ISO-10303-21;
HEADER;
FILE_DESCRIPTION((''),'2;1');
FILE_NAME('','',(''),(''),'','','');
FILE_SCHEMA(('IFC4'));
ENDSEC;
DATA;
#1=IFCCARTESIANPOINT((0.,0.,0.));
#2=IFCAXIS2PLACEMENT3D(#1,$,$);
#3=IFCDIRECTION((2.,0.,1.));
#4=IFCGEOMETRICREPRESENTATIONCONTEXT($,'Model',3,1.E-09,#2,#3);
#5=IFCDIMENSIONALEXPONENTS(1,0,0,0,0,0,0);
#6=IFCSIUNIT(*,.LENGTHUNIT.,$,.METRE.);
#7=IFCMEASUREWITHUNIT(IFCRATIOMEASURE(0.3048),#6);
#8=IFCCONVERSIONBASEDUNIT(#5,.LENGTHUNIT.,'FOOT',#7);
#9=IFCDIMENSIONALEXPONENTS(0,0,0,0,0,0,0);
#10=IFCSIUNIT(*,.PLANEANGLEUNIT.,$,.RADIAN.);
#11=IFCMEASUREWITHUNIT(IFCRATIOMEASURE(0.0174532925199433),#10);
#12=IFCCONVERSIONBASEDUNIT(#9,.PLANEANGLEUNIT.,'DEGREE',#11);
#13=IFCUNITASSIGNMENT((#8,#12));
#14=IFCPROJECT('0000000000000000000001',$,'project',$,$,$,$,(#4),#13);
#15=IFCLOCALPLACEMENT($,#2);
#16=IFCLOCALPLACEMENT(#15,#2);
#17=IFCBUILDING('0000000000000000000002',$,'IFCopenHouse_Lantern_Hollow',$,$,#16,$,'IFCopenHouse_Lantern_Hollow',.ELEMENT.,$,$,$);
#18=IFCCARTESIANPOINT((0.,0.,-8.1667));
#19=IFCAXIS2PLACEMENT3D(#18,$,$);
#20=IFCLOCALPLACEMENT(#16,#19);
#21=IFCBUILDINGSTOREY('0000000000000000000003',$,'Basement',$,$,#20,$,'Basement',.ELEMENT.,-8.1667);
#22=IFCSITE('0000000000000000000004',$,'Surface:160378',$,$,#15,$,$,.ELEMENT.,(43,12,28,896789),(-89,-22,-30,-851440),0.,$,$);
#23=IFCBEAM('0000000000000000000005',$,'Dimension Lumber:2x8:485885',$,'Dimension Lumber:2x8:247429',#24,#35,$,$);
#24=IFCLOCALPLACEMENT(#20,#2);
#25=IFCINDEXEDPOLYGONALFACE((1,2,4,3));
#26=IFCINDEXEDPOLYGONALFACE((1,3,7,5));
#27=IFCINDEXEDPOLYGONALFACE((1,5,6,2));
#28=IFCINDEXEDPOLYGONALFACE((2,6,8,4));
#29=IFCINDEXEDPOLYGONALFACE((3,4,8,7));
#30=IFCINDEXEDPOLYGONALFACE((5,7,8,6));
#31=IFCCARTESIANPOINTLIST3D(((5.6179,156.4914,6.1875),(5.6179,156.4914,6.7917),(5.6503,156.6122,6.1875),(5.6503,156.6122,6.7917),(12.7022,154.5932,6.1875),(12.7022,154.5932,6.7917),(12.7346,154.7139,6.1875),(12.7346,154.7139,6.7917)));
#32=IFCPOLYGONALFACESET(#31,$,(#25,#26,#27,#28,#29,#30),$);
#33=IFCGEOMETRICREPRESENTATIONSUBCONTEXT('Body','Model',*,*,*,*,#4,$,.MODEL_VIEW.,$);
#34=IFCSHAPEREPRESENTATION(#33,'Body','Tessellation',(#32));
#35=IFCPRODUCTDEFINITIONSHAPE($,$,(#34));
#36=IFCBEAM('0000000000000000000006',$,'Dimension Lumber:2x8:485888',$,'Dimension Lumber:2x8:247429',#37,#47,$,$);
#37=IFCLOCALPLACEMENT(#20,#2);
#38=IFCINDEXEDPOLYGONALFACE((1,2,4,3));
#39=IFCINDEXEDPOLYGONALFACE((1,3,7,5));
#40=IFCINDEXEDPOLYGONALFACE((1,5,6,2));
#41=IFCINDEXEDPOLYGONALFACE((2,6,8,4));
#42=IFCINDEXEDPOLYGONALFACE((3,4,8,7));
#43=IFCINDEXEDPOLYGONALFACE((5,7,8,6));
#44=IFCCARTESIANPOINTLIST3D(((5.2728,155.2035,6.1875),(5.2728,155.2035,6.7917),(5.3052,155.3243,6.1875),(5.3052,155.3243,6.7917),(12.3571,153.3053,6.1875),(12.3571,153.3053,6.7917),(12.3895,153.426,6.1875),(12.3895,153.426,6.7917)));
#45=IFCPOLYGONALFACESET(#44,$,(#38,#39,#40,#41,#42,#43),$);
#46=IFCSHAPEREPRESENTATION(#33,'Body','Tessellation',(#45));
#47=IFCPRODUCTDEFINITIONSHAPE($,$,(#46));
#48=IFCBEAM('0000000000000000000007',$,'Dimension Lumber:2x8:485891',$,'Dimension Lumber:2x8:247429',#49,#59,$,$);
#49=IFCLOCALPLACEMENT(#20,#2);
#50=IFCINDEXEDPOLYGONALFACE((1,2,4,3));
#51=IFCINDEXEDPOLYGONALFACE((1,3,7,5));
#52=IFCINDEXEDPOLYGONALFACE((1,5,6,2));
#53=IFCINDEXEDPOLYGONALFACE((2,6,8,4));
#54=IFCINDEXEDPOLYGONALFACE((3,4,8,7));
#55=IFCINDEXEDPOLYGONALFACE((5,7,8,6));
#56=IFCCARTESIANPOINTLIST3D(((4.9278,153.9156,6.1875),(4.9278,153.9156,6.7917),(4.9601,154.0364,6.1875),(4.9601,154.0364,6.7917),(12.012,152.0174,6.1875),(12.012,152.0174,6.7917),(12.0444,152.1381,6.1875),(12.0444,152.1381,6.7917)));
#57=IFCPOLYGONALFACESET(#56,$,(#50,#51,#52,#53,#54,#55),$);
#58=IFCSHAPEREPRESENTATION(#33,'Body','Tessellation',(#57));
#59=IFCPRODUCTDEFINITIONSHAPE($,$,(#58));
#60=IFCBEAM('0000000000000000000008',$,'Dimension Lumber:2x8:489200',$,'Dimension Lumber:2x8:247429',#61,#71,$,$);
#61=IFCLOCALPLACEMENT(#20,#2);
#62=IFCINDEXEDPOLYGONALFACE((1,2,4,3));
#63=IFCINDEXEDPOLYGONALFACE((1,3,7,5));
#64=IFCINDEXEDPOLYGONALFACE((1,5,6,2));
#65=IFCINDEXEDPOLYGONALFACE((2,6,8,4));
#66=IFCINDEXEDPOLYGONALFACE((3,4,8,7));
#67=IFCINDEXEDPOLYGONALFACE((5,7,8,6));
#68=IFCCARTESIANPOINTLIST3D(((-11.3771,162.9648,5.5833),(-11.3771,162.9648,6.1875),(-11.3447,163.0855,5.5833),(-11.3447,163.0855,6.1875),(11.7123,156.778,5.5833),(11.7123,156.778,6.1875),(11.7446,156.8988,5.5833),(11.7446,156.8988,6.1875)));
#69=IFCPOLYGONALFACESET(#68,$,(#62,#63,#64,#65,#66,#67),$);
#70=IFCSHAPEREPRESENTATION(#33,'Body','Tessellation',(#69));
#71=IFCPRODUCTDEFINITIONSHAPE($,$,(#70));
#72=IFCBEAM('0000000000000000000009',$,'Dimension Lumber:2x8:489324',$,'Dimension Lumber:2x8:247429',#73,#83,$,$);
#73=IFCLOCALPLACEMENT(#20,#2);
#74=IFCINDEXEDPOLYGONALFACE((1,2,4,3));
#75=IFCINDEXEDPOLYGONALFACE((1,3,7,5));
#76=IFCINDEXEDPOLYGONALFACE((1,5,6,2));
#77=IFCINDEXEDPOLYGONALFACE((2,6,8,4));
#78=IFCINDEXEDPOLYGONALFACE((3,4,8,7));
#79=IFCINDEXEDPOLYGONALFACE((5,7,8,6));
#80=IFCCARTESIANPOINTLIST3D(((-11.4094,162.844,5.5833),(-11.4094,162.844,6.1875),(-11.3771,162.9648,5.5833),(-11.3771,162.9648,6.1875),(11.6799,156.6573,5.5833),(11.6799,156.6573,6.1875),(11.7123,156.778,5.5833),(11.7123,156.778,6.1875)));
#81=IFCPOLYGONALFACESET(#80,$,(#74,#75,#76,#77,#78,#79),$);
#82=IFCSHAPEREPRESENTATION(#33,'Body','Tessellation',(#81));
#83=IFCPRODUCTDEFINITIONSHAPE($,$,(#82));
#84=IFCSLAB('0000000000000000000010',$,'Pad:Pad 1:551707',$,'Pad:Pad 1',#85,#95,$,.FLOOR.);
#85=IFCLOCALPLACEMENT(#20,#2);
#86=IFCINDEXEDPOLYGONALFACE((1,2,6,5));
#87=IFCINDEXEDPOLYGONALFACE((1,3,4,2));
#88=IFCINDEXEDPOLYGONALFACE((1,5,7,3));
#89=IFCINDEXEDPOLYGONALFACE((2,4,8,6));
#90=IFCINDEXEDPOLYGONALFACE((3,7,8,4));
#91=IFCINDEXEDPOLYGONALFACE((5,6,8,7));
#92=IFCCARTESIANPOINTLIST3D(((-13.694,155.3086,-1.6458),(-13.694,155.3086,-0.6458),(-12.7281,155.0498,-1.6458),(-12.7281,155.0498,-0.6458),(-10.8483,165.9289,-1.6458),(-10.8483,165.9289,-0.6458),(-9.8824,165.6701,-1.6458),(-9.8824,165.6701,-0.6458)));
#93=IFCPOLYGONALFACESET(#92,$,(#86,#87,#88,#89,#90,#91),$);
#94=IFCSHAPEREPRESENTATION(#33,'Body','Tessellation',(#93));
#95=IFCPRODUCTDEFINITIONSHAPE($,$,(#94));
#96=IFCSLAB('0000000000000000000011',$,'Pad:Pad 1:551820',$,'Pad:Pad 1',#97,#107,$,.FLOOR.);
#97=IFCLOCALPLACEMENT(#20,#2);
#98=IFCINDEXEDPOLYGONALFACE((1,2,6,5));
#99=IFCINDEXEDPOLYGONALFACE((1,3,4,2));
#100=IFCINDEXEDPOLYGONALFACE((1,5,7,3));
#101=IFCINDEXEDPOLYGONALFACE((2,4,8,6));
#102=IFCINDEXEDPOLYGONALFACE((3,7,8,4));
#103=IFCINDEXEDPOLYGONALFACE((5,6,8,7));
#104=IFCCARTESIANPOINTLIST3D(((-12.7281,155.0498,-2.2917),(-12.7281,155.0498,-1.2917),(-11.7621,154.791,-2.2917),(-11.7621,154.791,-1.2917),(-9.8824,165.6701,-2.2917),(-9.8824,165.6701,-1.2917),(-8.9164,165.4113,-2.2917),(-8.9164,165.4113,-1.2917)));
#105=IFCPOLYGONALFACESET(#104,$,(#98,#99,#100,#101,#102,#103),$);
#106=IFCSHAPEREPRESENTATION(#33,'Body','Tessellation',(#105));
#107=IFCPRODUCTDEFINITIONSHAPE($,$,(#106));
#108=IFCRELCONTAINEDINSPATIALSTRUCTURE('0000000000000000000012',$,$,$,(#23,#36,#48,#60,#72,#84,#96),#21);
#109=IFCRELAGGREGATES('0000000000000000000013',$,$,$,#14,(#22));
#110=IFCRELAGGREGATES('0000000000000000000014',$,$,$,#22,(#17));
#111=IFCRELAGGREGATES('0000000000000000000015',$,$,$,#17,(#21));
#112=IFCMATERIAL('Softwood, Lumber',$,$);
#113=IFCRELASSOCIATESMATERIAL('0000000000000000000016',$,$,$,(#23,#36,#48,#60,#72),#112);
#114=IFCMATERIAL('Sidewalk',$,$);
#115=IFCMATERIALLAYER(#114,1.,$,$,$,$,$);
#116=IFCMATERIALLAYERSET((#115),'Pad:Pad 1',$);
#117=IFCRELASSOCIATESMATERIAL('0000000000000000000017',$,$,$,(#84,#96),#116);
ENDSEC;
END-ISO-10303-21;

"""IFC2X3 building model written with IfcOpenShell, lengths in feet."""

from ifc_helpers import new_model, entity, si_unit, converted_unit, direction, frame, frame_2d, origin, place, context, subcontext, project, spatial, rectangle, extrude, material, layer, layer_set, layer_usage, element, save


model = new_model("IFC2X3")

# Units and contexts
model_context = context("Model", 3, precision=1e-09, world=origin(), true_north=direction((2.0, 0.0, 1.0)))
body_context = subcontext(model_context, "Body", "Model", "MODEL_VIEW")
ifc_project = project(units=[converted_unit("LENGTHUNIT", "FOOT", entity("IfcRatioMeasure", 0.3048), si_unit("LENGTHUNIT", "METRE"), dimensions=[1, 0, 0, 0, 0, 0, 0]), converted_unit("PLANEANGLEUNIT", "DEGREE", entity("IfcRatioMeasure", 0.0174532925199433), si_unit("PLANEANGLEUNIT", "RADIAN"), dimensions=[0, 0, 0, 0, 0, 0, 0])], contexts=[model_context])

# Site, building, storey
site_placement = place(None, origin())
site = spatial("IfcSite", under=ifc_project, at=site_placement, Name="Surface:160378", CompositionType="ELEMENT", RefLatitude=(43, 12, 28, 896789), RefLongitude=(-89, -22, -30, -851440), RefElevation=0.0)
building_placement = place(site_placement, origin())
building = spatial("IfcBuilding", under=site, at=building_placement, Name="IFCopenHouse_Lantern_Hollow", LongName="IFCopenHouse_Lantern_Hollow", CompositionType="ELEMENT")
storey_placement = place(building_placement, frame((0.0, 0.0, -8.1667)))
storey = spatial("IfcBuildingStorey", under=building, at=storey_placement, Name="Basement", LongName="Basement", CompositionType="ELEMENT", Elevation=-8.1667)

# Beams
ifc_material_1 = material(Name="Softwood, Lumber")
beam_1_placement = place(storey_placement, frame((5.6341, 156.5518, 8.1667), z_axis=(0.0, 0.0, 1.0), x_axis=(0.965926, -0.258819, 0.0)))
element("IfcBeam", 1, at=beam_1_placement, inside=storey, material=ifc_material_1, Name="Dimension Lumber:2x8:485885", ObjectType="Dimension Lumber:2x8:247429", context=body_context, shape_type="SweptSolid", body=[
    extrude(rectangle(XDim=0.6042, YDim=0.125, at=frame_2d((0.0, 0.0), x_axis=(1.0, 0.0))), frame((0.0, 0.0, -1.6771), z_axis=(1.0, 0.0, 0.0), x_axis=(0.0, 0.0, -1.0)), (0.0, 0.0, 1.0), 7.3342),
])
beam_2_placement = place(storey_placement, frame((5.289, 155.2639, 8.1667), z_axis=(0.0, 0.0, 1.0), x_axis=(0.965926, -0.258819, 0.0)))
element("IfcBeam", 2, at=beam_2_placement, inside=storey, material=ifc_material_1, Name="Dimension Lumber:2x8:485888", ObjectType="Dimension Lumber:2x8:247429", context=body_context, shape_type="SweptSolid", body=[
    extrude(rectangle(XDim=0.6042, YDim=0.125, at=frame_2d((0.0, 0.0), x_axis=(1.0, 0.0))), frame((0.0, 0.0, -1.6771), z_axis=(1.0, 0.0, 0.0), x_axis=(0.0, 0.0, -1.0)), (0.0, 0.0, 1.0), 7.3342),
])
beam_3_placement = place(storey_placement, frame((4.9439, 153.976, 8.1667), z_axis=(0.0, 0.0, 1.0), x_axis=(0.965926, -0.258819, 0.0)))
element("IfcBeam", 3, at=beam_3_placement, inside=storey, material=ifc_material_1, Name="Dimension Lumber:2x8:485891", ObjectType="Dimension Lumber:2x8:247429", context=body_context, shape_type="SweptSolid", body=[
    extrude(rectangle(XDim=0.6042, YDim=0.125, at=frame_2d((0.0, 0.0), x_axis=(1.0, 0.0))), frame((0.0, 0.0, -1.6771), z_axis=(1.0, 0.0, 0.0), x_axis=(0.0, 0.0, -1.0)), (0.0, 0.0, 1.0), 7.3342),
])
for number, where, z_axis, x_axis, name in (
    (4, (-11.3609, 163.0252, 8.1667), (0.0, 0.0, 1.0), (0.965926, -0.258819, 0.0), "Dimension Lumber:2x8:489200"),
    (5, (-11.3932, 162.9044, 8.1667), (0.0, 0.0, 1.0), (0.965926, -0.258819, 0.0), "Dimension Lumber:2x8:489324"),
):
    element("IfcBeam", number, at=place(storey_placement, frame(where, z_axis=z_axis, x_axis=x_axis)), inside=storey, material=ifc_material_1, Name=name, ObjectType="Dimension Lumber:2x8:247429", context=body_context, shape_type="SweptSolid", body=[
        extrude(rectangle(XDim=0.6042, YDim=0.125, at=frame_2d((0.0, 0.0), x_axis=(1.0, 0.0))), frame((0.0, 0.0, -2.2813), z_axis=(1.0, 0.0, 0.0), x_axis=(0.0, 0.0, -1.0)), (0.0, 0.0, 1.0), 23.9038),
    ])

# Slabs
ifc_material_2 = material(Name="Sidewalk")
ifc_layer = layer(ifc_material_2, 1.0)
ifc_layer_set = layer_set([ifc_layer], Name="Pad:Pad 1")
ifc_layer_usage_1 = layer_usage(ifc_layer_set, "AXIS3", "NEGATIVE", 0.0)
slab_1_placement = place(storey_placement, frame((-13.694, 155.0498, -1.6458)))
element("IfcSlab", 6, at=slab_1_placement, inside=storey, material=ifc_layer_usage_1, Name="Pad:Pad 1:551707", ObjectType="Pad:Pad 1", PredefinedType="FLOOR", context=body_context, shape_type="SweptSolid", body=[
    extrude(rectangle(XDim=1.0, YDim=10.9949, at=frame_2d((0.0, 0.0), x_axis=(0.965926, 0.258819))), frame((1.9058, 5.4396, 1.0), z_axis=(0.0, 0.0, -1.0), x_axis=(-1.0, 0.0, 0.0)), (0.0, 0.0, 1.0), 1.0),
])
ifc_layer_usage_2 = layer_usage(ifc_layer_set, "AXIS3", "NEGATIVE", 0.0)
slab_2_placement = place(storey_placement, frame((-12.7281, 154.791, -2.2917)))
element("IfcSlab", 7, at=slab_2_placement, inside=storey, material=ifc_layer_usage_2, Name="Pad:Pad 1:551820", ObjectType="Pad:Pad 1", PredefinedType="FLOOR", context=body_context, shape_type="SweptSolid", body=[
    extrude(rectangle(XDim=1.0, YDim=10.9949, at=frame_2d((0.0, 0.0), x_axis=(0.965926, 0.258819))), frame((1.9058, 5.4396, 1.0), z_axis=(0.0, 0.0, -1.0), x_axis=(-1.0, 0.0, 0.0)), (0.0, 0.0, 1.0), 1.0),
])

save(model, "model.ifc")
